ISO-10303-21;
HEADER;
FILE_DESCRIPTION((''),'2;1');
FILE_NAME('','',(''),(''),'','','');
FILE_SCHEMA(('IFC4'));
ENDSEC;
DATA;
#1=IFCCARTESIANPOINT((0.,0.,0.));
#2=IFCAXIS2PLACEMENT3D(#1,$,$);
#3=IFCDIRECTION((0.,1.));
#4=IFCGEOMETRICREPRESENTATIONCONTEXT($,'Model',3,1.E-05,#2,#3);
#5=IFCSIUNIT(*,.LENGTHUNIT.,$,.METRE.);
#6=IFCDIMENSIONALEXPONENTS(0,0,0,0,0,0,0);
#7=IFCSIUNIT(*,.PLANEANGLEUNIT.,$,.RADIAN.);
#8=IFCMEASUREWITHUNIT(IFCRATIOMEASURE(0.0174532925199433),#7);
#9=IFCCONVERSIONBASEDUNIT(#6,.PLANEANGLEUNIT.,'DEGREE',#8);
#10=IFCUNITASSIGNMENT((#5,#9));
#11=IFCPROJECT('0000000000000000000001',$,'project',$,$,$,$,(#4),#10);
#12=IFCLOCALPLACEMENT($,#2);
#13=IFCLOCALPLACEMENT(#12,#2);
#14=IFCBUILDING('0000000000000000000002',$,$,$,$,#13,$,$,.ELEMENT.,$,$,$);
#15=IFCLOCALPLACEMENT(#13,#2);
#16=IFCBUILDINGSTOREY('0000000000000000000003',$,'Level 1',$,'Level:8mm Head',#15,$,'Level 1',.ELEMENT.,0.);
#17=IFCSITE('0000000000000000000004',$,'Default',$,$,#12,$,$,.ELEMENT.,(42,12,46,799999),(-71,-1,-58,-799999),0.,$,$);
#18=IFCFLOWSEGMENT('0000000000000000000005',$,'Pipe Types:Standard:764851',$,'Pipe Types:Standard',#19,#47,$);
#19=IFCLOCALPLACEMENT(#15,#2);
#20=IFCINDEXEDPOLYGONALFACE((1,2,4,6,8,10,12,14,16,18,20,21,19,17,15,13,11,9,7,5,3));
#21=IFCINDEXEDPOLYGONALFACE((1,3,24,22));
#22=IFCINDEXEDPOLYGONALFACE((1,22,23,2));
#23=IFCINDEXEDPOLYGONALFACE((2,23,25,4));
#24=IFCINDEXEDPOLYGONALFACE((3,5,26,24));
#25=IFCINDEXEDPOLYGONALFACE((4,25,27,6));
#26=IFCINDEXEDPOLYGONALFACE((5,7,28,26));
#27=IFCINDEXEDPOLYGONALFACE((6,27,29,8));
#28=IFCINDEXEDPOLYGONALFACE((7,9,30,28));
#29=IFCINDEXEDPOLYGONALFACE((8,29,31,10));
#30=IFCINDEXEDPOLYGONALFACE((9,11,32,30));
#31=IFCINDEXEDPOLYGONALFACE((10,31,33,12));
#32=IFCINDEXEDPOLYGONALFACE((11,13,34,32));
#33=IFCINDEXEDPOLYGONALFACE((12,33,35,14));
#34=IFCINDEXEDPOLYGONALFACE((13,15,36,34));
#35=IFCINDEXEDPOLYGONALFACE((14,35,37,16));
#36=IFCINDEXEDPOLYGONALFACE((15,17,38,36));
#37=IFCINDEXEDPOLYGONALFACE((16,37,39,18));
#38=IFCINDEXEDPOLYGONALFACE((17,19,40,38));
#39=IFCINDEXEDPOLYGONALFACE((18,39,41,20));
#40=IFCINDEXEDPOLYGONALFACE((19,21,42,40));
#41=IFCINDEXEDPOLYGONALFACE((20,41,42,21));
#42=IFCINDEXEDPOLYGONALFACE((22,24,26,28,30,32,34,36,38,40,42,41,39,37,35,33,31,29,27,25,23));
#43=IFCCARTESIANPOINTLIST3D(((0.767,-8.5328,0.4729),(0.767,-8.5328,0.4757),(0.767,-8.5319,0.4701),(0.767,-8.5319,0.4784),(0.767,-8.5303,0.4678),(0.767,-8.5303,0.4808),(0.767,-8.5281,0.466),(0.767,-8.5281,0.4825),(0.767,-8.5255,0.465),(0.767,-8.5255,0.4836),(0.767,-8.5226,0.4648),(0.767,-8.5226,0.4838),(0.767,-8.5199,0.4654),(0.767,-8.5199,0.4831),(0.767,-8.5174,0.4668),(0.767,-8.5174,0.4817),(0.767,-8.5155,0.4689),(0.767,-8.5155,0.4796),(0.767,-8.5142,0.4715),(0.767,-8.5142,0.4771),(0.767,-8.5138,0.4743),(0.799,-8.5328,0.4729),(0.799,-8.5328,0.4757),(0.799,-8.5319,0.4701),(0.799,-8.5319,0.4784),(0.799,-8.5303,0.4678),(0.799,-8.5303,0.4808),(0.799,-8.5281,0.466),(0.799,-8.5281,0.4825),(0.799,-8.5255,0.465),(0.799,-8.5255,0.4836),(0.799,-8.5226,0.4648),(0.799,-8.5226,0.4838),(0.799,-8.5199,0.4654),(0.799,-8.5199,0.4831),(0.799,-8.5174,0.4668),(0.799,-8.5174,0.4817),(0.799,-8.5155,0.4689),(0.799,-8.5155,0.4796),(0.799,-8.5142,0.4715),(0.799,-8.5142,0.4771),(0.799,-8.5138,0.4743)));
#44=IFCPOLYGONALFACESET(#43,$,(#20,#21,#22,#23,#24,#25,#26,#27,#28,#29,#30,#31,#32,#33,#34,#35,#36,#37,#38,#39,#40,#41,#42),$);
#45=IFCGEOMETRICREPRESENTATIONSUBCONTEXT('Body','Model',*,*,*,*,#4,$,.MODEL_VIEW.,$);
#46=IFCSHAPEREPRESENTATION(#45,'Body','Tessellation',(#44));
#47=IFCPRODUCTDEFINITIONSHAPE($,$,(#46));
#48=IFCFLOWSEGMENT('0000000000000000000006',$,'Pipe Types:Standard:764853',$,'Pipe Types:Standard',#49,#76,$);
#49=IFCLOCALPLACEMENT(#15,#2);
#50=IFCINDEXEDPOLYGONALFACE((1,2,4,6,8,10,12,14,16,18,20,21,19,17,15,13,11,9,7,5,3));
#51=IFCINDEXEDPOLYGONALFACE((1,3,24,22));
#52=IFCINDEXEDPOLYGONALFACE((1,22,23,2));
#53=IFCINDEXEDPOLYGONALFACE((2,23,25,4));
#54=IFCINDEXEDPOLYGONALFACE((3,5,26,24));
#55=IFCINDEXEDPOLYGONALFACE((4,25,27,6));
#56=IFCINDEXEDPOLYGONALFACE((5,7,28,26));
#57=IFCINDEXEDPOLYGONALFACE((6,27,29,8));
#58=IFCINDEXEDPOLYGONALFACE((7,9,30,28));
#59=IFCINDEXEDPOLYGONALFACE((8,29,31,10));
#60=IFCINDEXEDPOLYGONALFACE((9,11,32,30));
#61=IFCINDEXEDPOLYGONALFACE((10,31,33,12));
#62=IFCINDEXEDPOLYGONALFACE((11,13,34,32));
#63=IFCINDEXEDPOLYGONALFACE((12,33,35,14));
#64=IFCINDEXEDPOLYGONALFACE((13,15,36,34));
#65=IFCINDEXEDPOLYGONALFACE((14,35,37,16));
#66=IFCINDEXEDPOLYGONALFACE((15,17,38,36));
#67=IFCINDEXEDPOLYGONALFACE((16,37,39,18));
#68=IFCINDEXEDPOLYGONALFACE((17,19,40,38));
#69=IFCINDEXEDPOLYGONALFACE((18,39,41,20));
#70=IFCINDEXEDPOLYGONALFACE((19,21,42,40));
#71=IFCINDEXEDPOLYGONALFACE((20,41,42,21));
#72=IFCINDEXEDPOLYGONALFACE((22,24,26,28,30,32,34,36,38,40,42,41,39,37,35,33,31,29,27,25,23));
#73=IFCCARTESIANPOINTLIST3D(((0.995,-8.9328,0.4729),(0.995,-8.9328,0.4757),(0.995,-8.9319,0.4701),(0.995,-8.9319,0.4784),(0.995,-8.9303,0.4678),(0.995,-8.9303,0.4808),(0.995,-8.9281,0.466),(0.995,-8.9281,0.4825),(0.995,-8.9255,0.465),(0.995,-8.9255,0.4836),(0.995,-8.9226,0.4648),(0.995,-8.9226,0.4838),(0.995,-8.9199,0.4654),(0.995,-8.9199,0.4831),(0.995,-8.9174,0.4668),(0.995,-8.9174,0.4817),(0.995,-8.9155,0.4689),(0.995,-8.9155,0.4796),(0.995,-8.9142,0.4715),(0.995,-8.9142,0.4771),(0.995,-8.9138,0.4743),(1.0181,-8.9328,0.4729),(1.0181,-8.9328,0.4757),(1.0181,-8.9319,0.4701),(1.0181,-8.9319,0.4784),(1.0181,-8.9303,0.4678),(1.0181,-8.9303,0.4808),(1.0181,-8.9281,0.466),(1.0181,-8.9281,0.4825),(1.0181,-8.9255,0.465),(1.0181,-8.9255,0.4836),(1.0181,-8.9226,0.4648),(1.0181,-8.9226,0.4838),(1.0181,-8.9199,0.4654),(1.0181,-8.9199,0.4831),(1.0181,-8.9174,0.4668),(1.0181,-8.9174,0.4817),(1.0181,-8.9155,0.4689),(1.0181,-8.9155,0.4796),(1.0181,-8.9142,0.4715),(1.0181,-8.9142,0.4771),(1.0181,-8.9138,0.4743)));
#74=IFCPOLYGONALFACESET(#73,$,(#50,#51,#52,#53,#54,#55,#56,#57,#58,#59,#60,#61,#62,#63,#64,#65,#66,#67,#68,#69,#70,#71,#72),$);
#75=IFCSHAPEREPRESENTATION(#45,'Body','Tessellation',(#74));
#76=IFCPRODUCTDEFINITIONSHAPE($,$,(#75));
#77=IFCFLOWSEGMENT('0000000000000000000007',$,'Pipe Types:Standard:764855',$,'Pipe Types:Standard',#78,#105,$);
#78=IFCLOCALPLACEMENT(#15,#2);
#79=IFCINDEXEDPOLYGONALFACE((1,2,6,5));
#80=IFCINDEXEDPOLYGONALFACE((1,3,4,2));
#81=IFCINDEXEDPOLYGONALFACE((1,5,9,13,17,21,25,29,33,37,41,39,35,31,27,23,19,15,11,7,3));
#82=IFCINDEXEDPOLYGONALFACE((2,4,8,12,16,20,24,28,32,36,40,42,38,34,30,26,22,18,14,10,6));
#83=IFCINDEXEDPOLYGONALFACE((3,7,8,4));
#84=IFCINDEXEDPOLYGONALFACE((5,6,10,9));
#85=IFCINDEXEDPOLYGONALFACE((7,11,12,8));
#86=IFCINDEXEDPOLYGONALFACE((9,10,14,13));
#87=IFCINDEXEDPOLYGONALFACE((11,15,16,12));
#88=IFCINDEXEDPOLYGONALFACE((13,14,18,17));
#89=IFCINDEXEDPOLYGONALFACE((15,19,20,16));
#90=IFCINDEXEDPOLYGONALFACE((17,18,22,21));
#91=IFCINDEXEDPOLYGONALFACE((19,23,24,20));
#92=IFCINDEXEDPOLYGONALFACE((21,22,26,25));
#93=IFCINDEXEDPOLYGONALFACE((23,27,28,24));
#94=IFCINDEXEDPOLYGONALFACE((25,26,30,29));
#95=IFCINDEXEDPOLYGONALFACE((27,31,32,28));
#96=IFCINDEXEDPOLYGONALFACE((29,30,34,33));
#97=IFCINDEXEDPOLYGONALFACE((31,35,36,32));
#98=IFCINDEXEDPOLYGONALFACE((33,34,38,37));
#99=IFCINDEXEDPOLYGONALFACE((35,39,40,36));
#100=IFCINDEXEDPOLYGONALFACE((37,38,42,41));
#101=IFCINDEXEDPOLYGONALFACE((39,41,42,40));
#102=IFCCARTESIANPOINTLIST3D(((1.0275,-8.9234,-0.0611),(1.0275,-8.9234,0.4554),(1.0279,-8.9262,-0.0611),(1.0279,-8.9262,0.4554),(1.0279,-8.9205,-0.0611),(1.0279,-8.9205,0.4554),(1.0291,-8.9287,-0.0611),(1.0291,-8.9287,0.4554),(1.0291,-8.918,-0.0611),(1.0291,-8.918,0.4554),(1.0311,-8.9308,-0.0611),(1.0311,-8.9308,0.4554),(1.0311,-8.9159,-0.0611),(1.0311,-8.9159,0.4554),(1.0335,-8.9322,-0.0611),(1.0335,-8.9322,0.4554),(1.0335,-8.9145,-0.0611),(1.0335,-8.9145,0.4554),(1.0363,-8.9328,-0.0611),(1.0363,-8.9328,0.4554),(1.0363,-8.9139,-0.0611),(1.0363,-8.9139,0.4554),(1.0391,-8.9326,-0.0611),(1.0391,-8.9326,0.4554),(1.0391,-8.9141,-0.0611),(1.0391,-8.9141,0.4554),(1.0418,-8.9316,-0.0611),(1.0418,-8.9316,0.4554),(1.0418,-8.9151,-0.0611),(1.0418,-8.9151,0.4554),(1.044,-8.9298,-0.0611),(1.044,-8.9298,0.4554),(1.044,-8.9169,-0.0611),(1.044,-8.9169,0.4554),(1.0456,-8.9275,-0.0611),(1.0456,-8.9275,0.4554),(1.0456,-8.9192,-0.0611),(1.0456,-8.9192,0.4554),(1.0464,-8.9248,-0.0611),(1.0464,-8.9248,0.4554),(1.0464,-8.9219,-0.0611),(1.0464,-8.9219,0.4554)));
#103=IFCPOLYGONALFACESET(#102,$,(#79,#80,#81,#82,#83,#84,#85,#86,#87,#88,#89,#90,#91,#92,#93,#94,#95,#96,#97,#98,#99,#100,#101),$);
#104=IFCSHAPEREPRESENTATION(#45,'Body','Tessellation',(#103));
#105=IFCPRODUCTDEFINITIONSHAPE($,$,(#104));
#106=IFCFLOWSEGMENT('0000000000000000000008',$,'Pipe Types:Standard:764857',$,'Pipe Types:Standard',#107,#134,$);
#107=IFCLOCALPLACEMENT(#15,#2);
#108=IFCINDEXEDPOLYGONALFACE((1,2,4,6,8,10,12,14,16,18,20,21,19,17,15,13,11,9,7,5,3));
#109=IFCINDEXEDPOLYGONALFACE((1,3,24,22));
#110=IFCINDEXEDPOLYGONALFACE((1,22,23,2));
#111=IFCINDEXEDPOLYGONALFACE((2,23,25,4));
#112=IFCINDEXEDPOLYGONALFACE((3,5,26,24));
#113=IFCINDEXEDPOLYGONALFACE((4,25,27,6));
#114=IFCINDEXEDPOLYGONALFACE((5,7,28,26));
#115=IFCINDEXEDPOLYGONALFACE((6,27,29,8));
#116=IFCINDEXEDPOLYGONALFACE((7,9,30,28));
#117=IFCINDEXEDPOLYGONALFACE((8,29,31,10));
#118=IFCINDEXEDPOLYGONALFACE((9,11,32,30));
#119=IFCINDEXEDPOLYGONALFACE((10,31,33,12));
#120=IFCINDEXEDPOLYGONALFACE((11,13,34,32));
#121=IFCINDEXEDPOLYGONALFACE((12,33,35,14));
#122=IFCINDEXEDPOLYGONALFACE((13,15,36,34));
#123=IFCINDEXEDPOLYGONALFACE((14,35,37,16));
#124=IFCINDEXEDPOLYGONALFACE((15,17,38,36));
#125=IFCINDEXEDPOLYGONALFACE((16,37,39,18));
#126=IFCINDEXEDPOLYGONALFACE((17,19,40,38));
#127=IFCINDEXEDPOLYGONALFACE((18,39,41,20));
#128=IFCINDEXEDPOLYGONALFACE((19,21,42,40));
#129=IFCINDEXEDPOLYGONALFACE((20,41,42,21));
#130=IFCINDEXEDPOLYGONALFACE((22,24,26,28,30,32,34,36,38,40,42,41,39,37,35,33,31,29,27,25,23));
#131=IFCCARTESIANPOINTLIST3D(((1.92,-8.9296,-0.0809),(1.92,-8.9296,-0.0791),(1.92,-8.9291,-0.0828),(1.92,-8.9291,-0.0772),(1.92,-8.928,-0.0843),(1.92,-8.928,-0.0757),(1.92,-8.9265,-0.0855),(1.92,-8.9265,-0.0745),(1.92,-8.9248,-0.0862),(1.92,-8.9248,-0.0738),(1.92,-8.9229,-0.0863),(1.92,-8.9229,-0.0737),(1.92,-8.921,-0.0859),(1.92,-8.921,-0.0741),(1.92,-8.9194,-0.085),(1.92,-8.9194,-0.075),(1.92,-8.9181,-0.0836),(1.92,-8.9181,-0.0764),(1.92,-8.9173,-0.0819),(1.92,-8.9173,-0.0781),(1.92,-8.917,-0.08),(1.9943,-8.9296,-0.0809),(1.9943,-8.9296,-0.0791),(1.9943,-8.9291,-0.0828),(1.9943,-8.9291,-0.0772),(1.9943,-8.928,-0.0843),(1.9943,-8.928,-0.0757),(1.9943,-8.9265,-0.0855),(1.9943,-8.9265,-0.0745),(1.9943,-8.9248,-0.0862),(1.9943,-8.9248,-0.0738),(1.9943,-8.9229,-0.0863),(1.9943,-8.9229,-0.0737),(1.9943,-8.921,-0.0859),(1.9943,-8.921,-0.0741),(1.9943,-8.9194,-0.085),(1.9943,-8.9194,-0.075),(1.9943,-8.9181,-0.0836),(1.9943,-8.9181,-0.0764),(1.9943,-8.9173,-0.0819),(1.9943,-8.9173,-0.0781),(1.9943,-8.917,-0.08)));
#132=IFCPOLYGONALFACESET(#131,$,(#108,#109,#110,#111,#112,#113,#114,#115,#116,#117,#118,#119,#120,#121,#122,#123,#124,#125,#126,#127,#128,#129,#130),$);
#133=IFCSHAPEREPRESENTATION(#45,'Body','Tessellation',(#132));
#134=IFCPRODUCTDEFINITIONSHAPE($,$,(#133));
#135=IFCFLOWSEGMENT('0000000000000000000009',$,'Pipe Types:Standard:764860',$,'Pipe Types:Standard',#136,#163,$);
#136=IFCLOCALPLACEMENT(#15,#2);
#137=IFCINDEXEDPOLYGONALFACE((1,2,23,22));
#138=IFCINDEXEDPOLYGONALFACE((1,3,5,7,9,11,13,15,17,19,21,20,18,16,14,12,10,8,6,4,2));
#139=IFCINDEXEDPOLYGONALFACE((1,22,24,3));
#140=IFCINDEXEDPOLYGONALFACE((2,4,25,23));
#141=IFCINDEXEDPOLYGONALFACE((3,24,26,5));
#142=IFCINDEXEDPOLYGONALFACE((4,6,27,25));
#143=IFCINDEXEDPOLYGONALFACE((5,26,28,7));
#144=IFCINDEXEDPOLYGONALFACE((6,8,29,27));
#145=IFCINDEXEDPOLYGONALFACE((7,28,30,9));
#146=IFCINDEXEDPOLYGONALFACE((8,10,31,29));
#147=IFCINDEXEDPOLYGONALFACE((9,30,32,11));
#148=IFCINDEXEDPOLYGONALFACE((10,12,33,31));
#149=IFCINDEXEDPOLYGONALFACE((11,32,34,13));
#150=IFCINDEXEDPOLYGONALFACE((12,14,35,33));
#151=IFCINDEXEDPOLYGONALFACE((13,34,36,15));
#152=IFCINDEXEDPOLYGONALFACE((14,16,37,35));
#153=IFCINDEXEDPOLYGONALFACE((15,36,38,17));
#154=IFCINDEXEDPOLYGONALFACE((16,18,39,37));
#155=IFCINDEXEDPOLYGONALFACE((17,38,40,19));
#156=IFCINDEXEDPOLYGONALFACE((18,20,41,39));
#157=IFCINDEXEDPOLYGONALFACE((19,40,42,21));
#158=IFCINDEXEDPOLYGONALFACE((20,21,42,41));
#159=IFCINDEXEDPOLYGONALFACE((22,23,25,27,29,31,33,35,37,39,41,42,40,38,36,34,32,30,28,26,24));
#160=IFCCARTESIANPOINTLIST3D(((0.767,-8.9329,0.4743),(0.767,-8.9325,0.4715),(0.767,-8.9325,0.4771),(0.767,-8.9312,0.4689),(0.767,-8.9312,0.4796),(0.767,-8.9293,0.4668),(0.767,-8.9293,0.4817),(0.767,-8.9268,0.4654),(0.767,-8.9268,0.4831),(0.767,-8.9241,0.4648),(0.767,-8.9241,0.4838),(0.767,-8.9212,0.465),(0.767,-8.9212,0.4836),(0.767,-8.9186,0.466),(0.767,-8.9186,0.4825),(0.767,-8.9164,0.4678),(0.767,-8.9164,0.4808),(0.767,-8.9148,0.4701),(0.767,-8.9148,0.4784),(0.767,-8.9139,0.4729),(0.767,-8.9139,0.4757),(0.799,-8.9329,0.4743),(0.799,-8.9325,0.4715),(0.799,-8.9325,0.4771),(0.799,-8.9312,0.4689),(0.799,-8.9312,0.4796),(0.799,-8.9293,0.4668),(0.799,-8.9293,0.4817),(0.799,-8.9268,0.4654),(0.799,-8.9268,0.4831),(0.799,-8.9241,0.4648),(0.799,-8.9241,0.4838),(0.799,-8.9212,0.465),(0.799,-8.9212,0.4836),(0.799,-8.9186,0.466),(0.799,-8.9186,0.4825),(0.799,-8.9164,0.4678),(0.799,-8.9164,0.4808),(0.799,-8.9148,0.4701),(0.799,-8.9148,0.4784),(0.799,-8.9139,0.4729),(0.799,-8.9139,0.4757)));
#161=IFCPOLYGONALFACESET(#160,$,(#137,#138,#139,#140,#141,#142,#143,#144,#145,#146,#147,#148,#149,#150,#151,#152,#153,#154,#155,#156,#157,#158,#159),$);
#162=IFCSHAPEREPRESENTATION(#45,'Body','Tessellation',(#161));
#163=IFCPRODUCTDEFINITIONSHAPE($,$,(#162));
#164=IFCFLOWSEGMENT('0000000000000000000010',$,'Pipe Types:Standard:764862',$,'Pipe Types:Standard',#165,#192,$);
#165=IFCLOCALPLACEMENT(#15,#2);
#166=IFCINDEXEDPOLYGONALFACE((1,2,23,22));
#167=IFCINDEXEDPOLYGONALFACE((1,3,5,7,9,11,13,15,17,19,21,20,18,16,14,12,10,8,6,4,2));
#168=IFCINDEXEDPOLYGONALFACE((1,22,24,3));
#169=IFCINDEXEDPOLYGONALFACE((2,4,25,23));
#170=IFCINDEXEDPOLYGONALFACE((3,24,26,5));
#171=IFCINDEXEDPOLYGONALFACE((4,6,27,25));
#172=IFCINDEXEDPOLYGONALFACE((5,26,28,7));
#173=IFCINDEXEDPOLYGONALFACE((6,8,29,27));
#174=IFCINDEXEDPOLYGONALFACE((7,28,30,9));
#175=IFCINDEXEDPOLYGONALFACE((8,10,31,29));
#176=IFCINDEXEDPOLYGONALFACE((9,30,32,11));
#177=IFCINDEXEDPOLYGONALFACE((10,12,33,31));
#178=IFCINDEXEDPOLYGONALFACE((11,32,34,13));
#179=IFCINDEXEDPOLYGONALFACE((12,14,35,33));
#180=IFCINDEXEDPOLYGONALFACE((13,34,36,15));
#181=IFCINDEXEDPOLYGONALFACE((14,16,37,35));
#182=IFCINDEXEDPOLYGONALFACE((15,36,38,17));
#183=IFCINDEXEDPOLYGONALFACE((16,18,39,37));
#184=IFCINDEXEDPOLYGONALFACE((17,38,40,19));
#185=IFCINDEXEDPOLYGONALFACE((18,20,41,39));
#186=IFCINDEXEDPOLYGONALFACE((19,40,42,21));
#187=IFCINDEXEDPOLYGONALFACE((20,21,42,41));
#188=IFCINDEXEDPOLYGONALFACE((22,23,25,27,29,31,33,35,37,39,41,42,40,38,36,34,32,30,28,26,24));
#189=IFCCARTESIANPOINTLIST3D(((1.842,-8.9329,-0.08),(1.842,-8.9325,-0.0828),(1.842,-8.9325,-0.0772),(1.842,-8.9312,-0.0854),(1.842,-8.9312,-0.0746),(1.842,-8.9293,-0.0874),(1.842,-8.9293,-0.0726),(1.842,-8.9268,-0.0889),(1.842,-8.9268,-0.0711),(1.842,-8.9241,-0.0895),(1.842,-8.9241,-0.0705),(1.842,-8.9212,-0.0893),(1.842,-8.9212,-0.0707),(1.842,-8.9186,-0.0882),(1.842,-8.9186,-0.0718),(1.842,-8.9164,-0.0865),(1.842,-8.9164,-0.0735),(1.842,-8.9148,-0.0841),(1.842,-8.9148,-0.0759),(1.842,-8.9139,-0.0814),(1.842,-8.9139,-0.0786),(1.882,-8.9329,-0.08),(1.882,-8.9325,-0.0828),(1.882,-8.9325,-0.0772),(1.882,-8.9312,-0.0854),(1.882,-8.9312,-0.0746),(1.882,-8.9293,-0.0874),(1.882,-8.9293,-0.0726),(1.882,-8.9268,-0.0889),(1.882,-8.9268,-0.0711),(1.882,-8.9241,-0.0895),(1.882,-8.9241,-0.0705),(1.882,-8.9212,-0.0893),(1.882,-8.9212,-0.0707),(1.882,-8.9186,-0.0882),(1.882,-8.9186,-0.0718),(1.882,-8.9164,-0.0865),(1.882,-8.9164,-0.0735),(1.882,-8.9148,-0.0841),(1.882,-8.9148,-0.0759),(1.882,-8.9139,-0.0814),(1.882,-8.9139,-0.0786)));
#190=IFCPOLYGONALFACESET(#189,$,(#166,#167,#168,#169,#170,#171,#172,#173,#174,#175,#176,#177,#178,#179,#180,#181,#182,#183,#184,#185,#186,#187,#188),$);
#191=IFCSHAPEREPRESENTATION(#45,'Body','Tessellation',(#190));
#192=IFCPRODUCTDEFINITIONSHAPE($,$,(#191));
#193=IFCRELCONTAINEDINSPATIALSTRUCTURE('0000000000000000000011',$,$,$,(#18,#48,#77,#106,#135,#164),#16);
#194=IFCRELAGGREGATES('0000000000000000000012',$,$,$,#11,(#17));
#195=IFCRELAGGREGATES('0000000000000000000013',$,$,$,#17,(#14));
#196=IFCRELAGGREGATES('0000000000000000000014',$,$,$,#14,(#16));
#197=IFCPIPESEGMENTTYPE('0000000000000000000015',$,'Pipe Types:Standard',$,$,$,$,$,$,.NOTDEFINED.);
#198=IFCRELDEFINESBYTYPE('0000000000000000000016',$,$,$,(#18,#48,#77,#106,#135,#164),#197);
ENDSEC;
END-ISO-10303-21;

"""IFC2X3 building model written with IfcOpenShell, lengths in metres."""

from ifc_helpers import new_model, entity, si_unit, converted_unit, direction, frame, frame_2d, origin, origin_2d_with_axis, place, context, subcontext, project, spatial, circle, extrude, type_object, element, save


model = new_model("IFC2X3")

# Units and contexts
model_context = context("Model", 3, precision=1e-05, world=origin(), true_north=direction((0.0, 1.0)))
body_context = subcontext(model_context, "Body", "Model", "MODEL_VIEW")
ifc_project = project(units=[si_unit("LENGTHUNIT", "METRE"), converted_unit("PLANEANGLEUNIT", "DEGREE", entity("IfcRatioMeasure", 0.0174532925199433), si_unit("PLANEANGLEUNIT", "RADIAN"), dimensions=[0, 0, 0, 0, 0, 0, 0])], contexts=[model_context])

# Site, building, storey
site_placement = place(None, origin())
site = spatial("IfcSite", under=ifc_project, at=site_placement, Name="Default", CompositionType="ELEMENT", RefLatitude=(42, 12, 46, 799999), RefLongitude=(-71, -1, -58, -799999), RefElevation=0.0)
building_placement = place(site_placement, origin())
building = spatial("IfcBuilding", under=site, at=building_placement, CompositionType="ELEMENT")
storey_placement = place(building_placement, origin())
storey = spatial("IfcBuildingStorey", under=building, at=storey_placement, Name="Level 1", ObjectType="Level:8mm Head", LongName="Level 1", CompositionType="ELEMENT", Elevation=0.0)

# Flow segments
pipe_segment_type = type_object("IfcPipeSegmentType", Name="Pipe Types:Standard", PredefinedType="NOTDEFINED")
flow_segment_1_placement = place(storey_placement, origin())
element("IfcFlowSegment", 1, at=flow_segment_1_placement, inside=storey, type_object=pipe_segment_type, Name="Pipe Types:Standard:764851", ObjectType="Pipe Types:Standard", context=body_context, shape_type="SweptSolid", body=[
    extrude(circle(Radius=0.0095, at=frame_2d((0.0, 0.0), x_axis=(1.0, 0.0))), frame((0.767, -8.5234, 0.4743), z_axis=(1.0, 0.0, 0.0), x_axis=(0.0, 1.0, 0.0)), (0.0, 0.0, 1.0), 0.032),
])
flow_segment_2_placement = place(storey_placement, origin())
element("IfcFlowSegment", 2, at=flow_segment_2_placement, inside=storey, type_object=pipe_segment_type, Name="Pipe Types:Standard:764853", ObjectType="Pipe Types:Standard", context=body_context, shape_type="SweptSolid", body=[
    extrude(circle(Radius=0.0095, at=frame_2d((0.0, 0.0), x_axis=(1.0, 0.0))), frame((0.995, -8.9234, 0.4743), z_axis=(1.0, 0.0, 0.0), x_axis=(0.0, 1.0, 0.0)), (0.0, 0.0, 1.0), 0.0231),
])
flow_segment_3_placement = place(storey_placement, origin())
element("IfcFlowSegment", 3, at=flow_segment_3_placement, inside=storey, type_object=pipe_segment_type, Name="Pipe Types:Standard:764855", ObjectType="Pipe Types:Standard", context=body_context, shape_type="SweptSolid", body=[
    extrude(circle(Radius=0.0095, at=origin_2d_with_axis()), frame((1.037, -8.9234, -0.0611), z_axis=(0.0, 0.0, 1.0), x_axis=(-1.0, 0.0, 0.0)), (0.0, 0.0, 1.0), 0.5165),
])
flow_segment_4_placement = place(storey_placement, origin())
element("IfcFlowSegment", 4, at=flow_segment_4_placement, inside=storey, type_object=pipe_segment_type, Name="Pipe Types:Standard:764857", ObjectType="Pipe Types:Standard", context=body_context, shape_type="SweptSolid", body=[
    extrude(circle(Radius=0.0063, at=frame_2d((0.0, 0.0), x_axis=(1.0, 0.0))), frame((1.92, -8.9234, -0.08), z_axis=(1.0, 0.0, 0.0), x_axis=(0.0, 1.0, 0.0)), (0.0, 0.0, 1.0), 0.0743),
])
flow_segment_5_placement = place(storey_placement, origin())
element("IfcFlowSegment", 5, at=flow_segment_5_placement, inside=storey, type_object=pipe_segment_type, Name="Pipe Types:Standard:764860", ObjectType="Pipe Types:Standard", context=body_context, shape_type="SweptSolid", body=[
    extrude(circle(Radius=0.0095, at=origin_2d_with_axis()), frame((0.767, -8.9234, 0.4743), z_axis=(1.0, 0.0, 0.0), x_axis=(0.0, -1.0, 0.0)), (0.0, 0.0, 1.0), 0.032),
])
flow_segment_6_placement = place(storey_placement, origin())
element("IfcFlowSegment", 6, at=flow_segment_6_placement, inside=storey, type_object=pipe_segment_type, Name="Pipe Types:Standard:764862", ObjectType="Pipe Types:Standard", context=body_context, shape_type="SweptSolid", body=[
    extrude(circle(Radius=0.0095, at=origin_2d_with_axis()), frame((1.842, -8.9234, -0.08), z_axis=(1.0, 0.0, 0.0), x_axis=(0.0, -1.0, 0.0)), (0.0, 0.0, 1.0), 0.04),
])

save(model, "model.ifc")
